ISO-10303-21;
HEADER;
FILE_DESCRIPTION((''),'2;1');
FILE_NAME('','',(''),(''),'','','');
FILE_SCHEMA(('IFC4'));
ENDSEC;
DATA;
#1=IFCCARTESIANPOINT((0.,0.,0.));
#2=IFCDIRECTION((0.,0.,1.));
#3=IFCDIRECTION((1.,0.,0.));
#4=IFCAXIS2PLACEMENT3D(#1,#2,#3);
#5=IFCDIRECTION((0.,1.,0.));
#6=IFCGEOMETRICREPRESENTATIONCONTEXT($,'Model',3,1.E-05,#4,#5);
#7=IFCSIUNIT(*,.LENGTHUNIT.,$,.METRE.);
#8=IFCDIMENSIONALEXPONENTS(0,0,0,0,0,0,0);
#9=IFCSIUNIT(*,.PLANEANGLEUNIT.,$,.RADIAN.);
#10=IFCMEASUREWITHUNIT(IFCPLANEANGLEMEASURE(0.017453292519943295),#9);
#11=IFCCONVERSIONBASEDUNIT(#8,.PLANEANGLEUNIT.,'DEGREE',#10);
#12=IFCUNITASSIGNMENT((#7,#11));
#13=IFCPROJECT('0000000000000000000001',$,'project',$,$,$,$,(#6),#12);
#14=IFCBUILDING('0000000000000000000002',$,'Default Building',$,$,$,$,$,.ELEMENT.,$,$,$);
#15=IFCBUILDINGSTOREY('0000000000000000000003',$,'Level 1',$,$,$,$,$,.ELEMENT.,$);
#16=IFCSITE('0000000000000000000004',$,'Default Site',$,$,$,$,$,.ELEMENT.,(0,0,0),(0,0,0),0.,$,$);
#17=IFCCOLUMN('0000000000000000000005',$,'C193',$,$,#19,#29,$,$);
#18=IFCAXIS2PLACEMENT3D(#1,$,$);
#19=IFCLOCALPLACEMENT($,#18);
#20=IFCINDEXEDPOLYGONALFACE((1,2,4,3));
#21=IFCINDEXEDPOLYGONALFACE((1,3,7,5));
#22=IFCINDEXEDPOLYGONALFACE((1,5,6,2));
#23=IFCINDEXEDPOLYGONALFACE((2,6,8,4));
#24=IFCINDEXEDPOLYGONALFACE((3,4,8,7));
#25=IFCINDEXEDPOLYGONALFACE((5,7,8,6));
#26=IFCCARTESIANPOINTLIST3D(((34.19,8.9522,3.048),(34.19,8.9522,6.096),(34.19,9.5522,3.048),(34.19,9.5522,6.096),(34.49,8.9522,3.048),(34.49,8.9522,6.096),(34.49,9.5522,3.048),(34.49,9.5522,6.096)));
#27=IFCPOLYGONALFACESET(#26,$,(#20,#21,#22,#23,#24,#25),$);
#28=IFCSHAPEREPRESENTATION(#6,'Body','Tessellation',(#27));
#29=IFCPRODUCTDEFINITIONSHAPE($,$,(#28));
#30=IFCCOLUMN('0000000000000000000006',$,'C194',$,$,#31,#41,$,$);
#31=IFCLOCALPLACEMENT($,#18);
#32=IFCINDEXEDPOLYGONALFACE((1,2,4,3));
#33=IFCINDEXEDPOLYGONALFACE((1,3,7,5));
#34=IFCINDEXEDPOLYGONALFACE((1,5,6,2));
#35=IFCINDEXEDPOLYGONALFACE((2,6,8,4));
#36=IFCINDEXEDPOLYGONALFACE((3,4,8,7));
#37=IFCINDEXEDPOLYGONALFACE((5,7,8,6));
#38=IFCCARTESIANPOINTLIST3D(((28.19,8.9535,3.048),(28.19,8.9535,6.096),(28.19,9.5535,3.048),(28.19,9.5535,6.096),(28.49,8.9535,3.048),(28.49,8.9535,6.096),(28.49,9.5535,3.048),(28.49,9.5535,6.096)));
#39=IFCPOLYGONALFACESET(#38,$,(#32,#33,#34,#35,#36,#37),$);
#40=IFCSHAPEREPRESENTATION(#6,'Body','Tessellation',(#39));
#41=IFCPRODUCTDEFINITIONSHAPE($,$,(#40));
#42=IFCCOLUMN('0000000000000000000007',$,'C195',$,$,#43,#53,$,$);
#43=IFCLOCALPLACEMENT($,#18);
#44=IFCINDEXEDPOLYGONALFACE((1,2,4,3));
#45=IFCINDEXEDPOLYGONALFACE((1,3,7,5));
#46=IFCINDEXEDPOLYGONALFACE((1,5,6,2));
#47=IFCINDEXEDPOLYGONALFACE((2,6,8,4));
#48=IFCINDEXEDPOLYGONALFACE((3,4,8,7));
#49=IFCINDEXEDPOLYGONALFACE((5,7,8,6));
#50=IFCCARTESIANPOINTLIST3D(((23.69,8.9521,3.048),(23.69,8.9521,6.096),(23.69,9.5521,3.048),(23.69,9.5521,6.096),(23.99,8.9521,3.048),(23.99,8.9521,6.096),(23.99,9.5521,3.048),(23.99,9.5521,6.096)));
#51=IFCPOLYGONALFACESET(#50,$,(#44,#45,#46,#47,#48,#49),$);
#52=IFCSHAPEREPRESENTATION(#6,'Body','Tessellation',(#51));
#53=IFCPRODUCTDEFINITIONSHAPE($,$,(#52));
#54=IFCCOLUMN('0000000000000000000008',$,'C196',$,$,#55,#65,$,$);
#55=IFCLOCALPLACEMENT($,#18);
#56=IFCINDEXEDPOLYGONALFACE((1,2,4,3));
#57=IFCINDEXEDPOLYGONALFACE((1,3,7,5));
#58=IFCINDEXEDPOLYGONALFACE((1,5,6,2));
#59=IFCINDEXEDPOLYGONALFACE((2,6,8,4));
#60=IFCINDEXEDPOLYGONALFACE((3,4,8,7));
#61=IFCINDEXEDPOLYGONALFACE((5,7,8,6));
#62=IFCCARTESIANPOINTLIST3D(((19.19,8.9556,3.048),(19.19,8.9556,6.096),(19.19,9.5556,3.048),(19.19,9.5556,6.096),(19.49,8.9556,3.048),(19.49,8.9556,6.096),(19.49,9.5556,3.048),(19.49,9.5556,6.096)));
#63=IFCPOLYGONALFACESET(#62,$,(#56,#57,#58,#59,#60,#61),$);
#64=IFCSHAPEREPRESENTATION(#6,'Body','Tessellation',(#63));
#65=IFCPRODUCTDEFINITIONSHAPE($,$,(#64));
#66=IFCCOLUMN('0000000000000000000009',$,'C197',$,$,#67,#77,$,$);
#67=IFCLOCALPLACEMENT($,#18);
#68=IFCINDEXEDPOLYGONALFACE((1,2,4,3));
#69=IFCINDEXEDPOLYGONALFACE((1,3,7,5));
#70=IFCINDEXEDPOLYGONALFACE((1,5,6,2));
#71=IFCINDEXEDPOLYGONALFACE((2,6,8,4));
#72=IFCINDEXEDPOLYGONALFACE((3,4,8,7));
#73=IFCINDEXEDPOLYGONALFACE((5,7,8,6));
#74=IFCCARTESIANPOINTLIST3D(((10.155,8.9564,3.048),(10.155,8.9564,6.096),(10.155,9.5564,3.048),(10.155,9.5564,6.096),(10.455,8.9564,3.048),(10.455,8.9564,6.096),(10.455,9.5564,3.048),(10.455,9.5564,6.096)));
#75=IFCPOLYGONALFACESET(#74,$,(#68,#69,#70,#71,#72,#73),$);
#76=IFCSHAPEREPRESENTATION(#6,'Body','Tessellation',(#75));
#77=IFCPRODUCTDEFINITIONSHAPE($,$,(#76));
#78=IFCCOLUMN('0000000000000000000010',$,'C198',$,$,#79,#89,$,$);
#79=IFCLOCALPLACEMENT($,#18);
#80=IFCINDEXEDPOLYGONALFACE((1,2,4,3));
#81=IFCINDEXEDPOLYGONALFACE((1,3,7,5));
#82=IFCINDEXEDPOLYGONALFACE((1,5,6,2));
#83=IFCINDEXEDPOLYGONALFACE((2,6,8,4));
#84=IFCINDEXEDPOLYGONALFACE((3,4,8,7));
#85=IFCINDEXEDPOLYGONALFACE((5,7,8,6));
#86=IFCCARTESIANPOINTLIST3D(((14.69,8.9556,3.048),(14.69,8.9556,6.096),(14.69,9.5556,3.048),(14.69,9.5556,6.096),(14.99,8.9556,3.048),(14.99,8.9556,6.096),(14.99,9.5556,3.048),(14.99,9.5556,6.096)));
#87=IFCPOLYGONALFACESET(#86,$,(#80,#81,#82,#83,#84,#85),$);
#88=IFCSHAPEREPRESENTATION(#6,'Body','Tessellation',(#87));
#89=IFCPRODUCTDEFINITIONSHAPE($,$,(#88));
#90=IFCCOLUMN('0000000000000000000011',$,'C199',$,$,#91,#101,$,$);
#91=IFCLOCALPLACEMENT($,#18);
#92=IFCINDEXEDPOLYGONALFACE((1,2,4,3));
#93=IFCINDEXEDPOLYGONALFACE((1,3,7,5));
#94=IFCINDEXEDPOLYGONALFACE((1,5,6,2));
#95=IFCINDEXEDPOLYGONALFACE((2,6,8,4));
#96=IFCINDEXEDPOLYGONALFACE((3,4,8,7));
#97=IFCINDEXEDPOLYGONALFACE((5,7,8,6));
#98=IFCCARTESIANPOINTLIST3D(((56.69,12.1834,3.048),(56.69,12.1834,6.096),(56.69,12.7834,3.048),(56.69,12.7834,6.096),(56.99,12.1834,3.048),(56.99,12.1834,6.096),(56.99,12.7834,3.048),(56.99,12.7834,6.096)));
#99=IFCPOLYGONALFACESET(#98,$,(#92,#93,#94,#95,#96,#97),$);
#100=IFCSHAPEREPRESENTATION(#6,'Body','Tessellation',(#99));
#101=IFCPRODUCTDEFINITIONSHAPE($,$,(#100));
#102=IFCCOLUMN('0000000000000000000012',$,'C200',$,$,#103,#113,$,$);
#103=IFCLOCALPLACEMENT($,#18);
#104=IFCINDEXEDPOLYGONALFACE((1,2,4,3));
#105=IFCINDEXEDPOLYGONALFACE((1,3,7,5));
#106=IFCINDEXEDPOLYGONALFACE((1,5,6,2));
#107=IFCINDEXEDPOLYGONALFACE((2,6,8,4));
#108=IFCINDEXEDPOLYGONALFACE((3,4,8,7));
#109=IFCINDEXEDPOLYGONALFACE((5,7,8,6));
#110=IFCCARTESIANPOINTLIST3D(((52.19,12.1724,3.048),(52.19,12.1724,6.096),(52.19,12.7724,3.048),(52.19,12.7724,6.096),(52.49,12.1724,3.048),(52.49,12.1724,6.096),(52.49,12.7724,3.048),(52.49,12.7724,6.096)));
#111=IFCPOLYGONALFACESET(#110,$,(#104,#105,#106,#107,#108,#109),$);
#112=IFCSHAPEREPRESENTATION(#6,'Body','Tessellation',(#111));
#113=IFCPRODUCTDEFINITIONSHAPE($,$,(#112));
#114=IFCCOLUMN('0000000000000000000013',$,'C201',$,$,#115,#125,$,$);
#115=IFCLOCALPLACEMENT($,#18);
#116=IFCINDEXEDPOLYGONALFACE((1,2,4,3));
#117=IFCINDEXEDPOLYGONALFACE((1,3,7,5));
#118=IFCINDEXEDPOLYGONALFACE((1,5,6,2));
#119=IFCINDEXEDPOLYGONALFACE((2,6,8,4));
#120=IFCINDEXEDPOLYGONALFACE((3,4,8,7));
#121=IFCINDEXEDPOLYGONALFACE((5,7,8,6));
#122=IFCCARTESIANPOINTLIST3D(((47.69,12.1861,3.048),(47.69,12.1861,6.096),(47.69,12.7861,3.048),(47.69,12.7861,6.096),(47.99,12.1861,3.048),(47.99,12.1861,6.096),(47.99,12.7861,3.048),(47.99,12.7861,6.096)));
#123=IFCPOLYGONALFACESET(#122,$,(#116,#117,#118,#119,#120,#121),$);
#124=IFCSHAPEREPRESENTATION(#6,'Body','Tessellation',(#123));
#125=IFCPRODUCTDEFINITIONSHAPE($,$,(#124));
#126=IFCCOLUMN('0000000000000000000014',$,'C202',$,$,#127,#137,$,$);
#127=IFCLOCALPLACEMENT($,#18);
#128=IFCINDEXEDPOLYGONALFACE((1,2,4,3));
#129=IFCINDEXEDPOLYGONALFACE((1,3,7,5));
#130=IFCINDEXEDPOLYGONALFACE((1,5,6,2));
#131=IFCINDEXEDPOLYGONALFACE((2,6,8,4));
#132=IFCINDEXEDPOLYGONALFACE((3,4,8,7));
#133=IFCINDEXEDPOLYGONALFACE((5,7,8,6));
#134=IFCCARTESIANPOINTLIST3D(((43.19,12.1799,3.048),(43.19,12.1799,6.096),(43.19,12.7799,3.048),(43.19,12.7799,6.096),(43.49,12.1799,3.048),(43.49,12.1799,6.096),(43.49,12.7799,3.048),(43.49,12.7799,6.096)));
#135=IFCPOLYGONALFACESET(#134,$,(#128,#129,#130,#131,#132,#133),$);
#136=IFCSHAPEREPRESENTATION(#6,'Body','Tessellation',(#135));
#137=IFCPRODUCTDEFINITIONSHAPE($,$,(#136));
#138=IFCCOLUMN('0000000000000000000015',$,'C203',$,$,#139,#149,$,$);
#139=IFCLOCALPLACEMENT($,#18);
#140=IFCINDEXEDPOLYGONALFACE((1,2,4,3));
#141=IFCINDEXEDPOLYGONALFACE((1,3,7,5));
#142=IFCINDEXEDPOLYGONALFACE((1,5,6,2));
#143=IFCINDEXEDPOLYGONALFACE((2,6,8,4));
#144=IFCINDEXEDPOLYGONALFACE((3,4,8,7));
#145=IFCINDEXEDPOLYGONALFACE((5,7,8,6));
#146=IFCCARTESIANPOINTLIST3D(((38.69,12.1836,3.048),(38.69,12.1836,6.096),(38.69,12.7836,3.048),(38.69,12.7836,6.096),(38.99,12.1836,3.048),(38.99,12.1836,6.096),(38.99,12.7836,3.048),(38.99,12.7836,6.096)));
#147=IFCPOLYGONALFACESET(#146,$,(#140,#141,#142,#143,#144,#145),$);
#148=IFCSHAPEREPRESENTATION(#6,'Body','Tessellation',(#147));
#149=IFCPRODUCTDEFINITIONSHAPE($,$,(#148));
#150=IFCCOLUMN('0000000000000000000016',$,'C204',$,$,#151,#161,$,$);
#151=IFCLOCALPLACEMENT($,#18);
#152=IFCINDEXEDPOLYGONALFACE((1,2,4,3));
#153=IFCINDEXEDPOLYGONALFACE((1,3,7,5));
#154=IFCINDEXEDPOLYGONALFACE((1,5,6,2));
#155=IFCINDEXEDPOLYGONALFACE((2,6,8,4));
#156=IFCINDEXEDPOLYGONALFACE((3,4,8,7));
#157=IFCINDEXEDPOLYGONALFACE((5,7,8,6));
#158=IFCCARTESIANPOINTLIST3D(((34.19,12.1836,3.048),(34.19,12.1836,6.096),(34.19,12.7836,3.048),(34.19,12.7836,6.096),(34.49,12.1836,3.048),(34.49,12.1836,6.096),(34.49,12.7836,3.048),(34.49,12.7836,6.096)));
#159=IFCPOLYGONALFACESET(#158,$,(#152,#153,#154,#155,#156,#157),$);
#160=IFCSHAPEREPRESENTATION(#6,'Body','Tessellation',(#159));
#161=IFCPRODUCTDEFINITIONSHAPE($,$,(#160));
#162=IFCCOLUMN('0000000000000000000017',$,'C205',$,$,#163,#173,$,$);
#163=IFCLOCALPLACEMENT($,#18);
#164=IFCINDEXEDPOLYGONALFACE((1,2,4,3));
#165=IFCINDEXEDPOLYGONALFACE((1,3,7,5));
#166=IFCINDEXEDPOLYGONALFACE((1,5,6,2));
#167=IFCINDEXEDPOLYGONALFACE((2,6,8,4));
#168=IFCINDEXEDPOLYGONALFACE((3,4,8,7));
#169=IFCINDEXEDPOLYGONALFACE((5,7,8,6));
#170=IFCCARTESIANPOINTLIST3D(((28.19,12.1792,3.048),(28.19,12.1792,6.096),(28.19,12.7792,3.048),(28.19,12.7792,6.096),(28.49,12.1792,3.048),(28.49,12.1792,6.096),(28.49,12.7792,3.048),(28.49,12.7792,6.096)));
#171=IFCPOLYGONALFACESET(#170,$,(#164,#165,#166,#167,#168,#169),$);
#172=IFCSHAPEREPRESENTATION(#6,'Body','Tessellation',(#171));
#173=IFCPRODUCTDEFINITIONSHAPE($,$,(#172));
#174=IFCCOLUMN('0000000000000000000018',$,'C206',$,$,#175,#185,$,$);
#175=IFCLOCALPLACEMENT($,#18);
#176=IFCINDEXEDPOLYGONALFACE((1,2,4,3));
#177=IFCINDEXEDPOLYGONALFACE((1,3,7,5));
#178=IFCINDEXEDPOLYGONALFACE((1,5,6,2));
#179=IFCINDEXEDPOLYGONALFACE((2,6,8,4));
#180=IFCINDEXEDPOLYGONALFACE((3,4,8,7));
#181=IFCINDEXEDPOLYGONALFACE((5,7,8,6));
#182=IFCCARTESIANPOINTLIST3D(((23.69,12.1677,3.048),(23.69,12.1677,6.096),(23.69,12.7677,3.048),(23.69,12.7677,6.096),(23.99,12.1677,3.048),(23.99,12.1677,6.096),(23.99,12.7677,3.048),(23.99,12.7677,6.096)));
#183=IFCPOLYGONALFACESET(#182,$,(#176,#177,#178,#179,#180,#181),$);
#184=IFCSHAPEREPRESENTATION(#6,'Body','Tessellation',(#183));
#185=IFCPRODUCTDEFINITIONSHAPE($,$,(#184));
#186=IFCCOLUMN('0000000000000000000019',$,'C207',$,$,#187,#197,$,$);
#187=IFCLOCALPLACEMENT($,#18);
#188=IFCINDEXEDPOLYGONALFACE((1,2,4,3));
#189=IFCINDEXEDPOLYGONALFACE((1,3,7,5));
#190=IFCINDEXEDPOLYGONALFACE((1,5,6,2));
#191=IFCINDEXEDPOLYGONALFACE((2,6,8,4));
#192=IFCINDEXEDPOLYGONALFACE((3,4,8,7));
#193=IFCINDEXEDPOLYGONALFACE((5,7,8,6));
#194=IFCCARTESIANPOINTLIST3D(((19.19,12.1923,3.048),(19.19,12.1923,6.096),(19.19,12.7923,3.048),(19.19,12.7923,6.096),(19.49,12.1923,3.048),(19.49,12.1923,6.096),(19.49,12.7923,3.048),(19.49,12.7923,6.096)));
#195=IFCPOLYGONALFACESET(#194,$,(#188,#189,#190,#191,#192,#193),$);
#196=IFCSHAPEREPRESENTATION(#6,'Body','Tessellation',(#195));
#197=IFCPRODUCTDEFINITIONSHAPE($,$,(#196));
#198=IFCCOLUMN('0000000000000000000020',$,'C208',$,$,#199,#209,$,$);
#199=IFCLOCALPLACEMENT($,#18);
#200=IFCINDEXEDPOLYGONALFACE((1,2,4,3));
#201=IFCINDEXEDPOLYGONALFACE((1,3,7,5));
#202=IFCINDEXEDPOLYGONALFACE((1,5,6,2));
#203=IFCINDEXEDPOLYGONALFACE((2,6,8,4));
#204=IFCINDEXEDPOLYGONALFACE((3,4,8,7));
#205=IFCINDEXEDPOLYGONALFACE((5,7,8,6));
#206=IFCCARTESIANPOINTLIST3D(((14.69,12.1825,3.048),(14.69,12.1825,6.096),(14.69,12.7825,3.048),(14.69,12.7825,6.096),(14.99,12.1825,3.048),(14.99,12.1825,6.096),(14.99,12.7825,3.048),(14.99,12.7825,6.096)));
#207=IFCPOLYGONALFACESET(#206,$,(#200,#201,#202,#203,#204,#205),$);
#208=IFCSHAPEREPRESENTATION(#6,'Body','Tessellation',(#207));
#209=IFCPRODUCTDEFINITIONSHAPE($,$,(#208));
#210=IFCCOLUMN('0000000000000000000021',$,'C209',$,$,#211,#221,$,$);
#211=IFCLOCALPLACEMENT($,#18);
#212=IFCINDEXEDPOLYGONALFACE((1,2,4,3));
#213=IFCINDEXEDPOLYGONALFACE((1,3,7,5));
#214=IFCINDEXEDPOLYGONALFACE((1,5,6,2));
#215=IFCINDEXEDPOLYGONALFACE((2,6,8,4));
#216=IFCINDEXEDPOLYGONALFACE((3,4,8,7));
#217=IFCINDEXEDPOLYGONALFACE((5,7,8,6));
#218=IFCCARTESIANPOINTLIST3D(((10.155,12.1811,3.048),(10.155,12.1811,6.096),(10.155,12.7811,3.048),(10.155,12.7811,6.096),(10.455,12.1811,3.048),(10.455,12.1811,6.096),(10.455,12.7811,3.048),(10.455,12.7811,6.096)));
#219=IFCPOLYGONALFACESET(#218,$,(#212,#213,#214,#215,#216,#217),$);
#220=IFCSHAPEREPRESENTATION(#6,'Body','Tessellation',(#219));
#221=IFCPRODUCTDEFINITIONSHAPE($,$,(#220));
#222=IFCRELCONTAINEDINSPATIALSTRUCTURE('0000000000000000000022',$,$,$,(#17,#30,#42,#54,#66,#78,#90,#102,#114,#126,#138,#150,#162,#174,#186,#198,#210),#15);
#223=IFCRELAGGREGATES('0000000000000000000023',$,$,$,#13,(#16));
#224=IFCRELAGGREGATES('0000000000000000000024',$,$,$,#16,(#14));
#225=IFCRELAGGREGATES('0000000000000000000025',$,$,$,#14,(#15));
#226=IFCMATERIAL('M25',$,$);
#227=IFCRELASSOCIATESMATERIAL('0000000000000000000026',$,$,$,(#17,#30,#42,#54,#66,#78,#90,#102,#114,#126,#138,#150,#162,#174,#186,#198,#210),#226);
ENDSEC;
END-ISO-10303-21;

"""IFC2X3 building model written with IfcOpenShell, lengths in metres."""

from ifc_helpers import new_model, entity, si_unit, converted_unit, direction, frame, frame_2d, origin_with_axes, place, context, project, spatial, rectangle, extrude, material, element, save


model = new_model("IFC2X3")

# Units and contexts
model_context = context("Model", 3, precision=1e-05, world=origin_with_axes(), true_north=direction((0.0, 1.0, 0.0)))
ifc_project = project(units=[si_unit("LENGTHUNIT", "METRE"), converted_unit("PLANEANGLEUNIT", "DEGREE", entity("IfcPlaneAngleMeasure", 0.017453292519943295), si_unit("PLANEANGLEUNIT", "RADIAN"), dimensions=[0, 0, 0, 0, 0, 0, 0])], contexts=[model_context])

# Site, building, storey
site = spatial("IfcSite", under=ifc_project, Name="Default Site", CompositionType="ELEMENT", RefLatitude=(0, 0, 0), RefLongitude=(0, 0, 0), RefElevation=0.0)
building = spatial("IfcBuilding", under=site, Name="Default Building", CompositionType="ELEMENT")
storey = spatial("IfcBuildingStorey", under=building, Name="Level 1", CompositionType="ELEMENT")

# Columns
ifc_material = material(Name="M25")
placement = place(None, origin_with_axes())
element("IfcColumn", 1, at=placement, inside=storey, material=ifc_material, Name="C193", context=model_context, shape_type="SweptSolid", body=[
    extrude(rectangle(XDim=0.3, YDim=0.6, at=frame_2d((0.0, 0.0), x_axis=(1.0, 0.0, 0.0))), frame((34.34, 9.2522, 3.048), z_axis=(0.0, 0.0, 1.0), x_axis=(1.0, 0.0, 0.0)), (0.0, 0.0, 1.0), 3.048),
])
element("IfcColumn", 2, at=placement, inside=storey, material=ifc_material, Name="C194", context=model_context, shape_type="SweptSolid", body=[
    extrude(rectangle(XDim=0.3, YDim=0.6, at=frame_2d((0.0, 0.0), x_axis=(1.0, 0.0, 0.0))), frame((28.34, 9.2535, 3.048), z_axis=(0.0, 0.0, 1.0), x_axis=(1.0, 0.0, 0.0)), (0.0, 0.0, 1.0), 3.048),
])
element("IfcColumn", 3, at=placement, inside=storey, material=ifc_material, Name="C195", context=model_context, shape_type="SweptSolid", body=[
    extrude(rectangle(XDim=0.3, YDim=0.6, at=frame_2d((0.0, 0.0), x_axis=(1.0, 0.0, 0.0))), frame((23.84, 9.2521, 3.048), z_axis=(0.0, 0.0, 1.0), x_axis=(1.0, 0.0, 0.0)), (0.0, 0.0, 1.0), 3.048),
])
element("IfcColumn", 4, at=placement, inside=storey, material=ifc_material, Name="C196", context=model_context, shape_type="SweptSolid", body=[
    extrude(rectangle(XDim=0.3, YDim=0.6, at=frame_2d((0.0, 0.0), x_axis=(1.0, 0.0, 0.0))), frame((19.34, 9.2556, 3.048), z_axis=(0.0, 0.0, 1.0), x_axis=(1.0, 0.0, 0.0)), (0.0, 0.0, 1.0), 3.048),
])
element("IfcColumn", 5, at=placement, inside=storey, material=ifc_material, Name="C197", context=model_context, shape_type="SweptSolid", body=[
    extrude(rectangle(XDim=0.3, YDim=0.6, at=frame_2d((0.0, 0.0), x_axis=(1.0, 0.0, 0.0))), frame((10.305, 9.2564, 3.048), z_axis=(0.0, 0.0, 1.0), x_axis=(1.0, 0.0, 0.0)), (0.0, 0.0, 1.0), 3.048),
])
element("IfcColumn", 6, at=placement, inside=storey, material=ifc_material, Name="C198", context=model_context, shape_type="SweptSolid", body=[
    extrude(rectangle(XDim=0.3, YDim=0.6, at=frame_2d((0.0, 0.0), x_axis=(1.0, 0.0, 0.0))), frame((14.84, 9.2556, 3.048), z_axis=(0.0, 0.0, 1.0), x_axis=(1.0, 0.0, 0.0)), (0.0, 0.0, 1.0), 3.048),
])
element("IfcColumn", 7, at=placement, inside=storey, material=ifc_material, Name="C199", context=model_context, shape_type="SweptSolid", body=[
    extrude(rectangle(XDim=0.3, YDim=0.6, at=frame_2d((0.0, 0.0), x_axis=(1.0, 0.0, 0.0))), frame((56.84, 12.4834, 3.048), z_axis=(0.0, 0.0, 1.0), x_axis=(1.0, 0.0, 0.0)), (0.0, 0.0, 1.0), 3.048),
])
element("IfcColumn", 8, at=placement, inside=storey, material=ifc_material, Name="C200", context=model_context, shape_type="SweptSolid", body=[
    extrude(rectangle(XDim=0.3, YDim=0.6, at=frame_2d((0.0, 0.0), x_axis=(1.0, 0.0, 0.0))), frame((52.34, 12.4724, 3.048), z_axis=(0.0, 0.0, 1.0), x_axis=(1.0, 0.0, 0.0)), (0.0, 0.0, 1.0), 3.048),
])
element("IfcColumn", 9, at=placement, inside=storey, material=ifc_material, Name="C201", context=model_context, shape_type="SweptSolid", body=[
    extrude(rectangle(XDim=0.3, YDim=0.6, at=frame_2d((0.0, 0.0), x_axis=(1.0, 0.0, 0.0))), frame((47.84, 12.4861, 3.048), z_axis=(0.0, 0.0, 1.0), x_axis=(1.0, 0.0, 0.0)), (0.0, 0.0, 1.0), 3.048),
])
element("IfcColumn", 10, at=placement, inside=storey, material=ifc_material, Name="C202", context=model_context, shape_type="SweptSolid", body=[
    extrude(rectangle(XDim=0.3, YDim=0.6, at=frame_2d((0.0, 0.0), x_axis=(1.0, 0.0, 0.0))), frame((43.34, 12.4799, 3.048), z_axis=(0.0, 0.0, 1.0), x_axis=(1.0, 0.0, 0.0)), (0.0, 0.0, 1.0), 3.048),
])
element("IfcColumn", 11, at=placement, inside=storey, material=ifc_material, Name="C203", context=model_context, shape_type="SweptSolid", body=[
    extrude(rectangle(XDim=0.3, YDim=0.6, at=frame_2d((0.0, 0.0), x_axis=(1.0, 0.0, 0.0))), frame((38.84, 12.4836, 3.048), z_axis=(0.0, 0.0, 1.0), x_axis=(1.0, 0.0, 0.0)), (0.0, 0.0, 1.0), 3.048),
])
element("IfcColumn", 12, at=placement, inside=storey, material=ifc_material, Name="C204", context=model_context, shape_type="SweptSolid", body=[
    extrude(rectangle(XDim=0.3, YDim=0.6, at=frame_2d((0.0, 0.0), x_axis=(1.0, 0.0, 0.0))), frame((34.34, 12.4836, 3.048), z_axis=(0.0, 0.0, 1.0), x_axis=(1.0, 0.0, 0.0)), (0.0, 0.0, 1.0), 3.048),
])
element("IfcColumn", 13, at=placement, inside=storey, material=ifc_material, Name="C205", context=model_context, shape_type="SweptSolid", body=[
    extrude(rectangle(XDim=0.3, YDim=0.6, at=frame_2d((0.0, 0.0), x_axis=(1.0, 0.0, 0.0))), frame((28.34, 12.4792, 3.048), z_axis=(0.0, 0.0, 1.0), x_axis=(1.0, 0.0, 0.0)), (0.0, 0.0, 1.0), 3.048),
])
element("IfcColumn", 14, at=placement, inside=storey, material=ifc_material, Name="C206", context=model_context, shape_type="SweptSolid", body=[
    extrude(rectangle(XDim=0.3, YDim=0.6, at=frame_2d((0.0, 0.0), x_axis=(1.0, 0.0, 0.0))), frame((23.84, 12.4677, 3.048), z_axis=(0.0, 0.0, 1.0), x_axis=(1.0, 0.0, 0.0)), (0.0, 0.0, 1.0), 3.048),
])
element("IfcColumn", 15, at=placement, inside=storey, material=ifc_material, Name="C207", context=model_context, shape_type="SweptSolid", body=[
    extrude(rectangle(XDim=0.3, YDim=0.6, at=frame_2d((0.0, 0.0), x_axis=(1.0, 0.0, 0.0))), frame((19.34, 12.4923, 3.048), z_axis=(0.0, 0.0, 1.0), x_axis=(1.0, 0.0, 0.0)), (0.0, 0.0, 1.0), 3.048),
])
element("IfcColumn", 16, at=placement, inside=storey, material=ifc_material, Name="C208", context=model_context, shape_type="SweptSolid", body=[
    extrude(rectangle(XDim=0.3, YDim=0.6, at=frame_2d((0.0, 0.0), x_axis=(1.0, 0.0, 0.0))), frame((14.84, 12.4825, 3.048), z_axis=(0.0, 0.0, 1.0), x_axis=(1.0, 0.0, 0.0)), (0.0, 0.0, 1.0), 3.048),
])
element("IfcColumn", 17, at=placement, inside=storey, material=ifc_material, Name="C209", context=model_context, shape_type="SweptSolid", body=[
    extrude(rectangle(XDim=0.3, YDim=0.6, at=frame_2d((0.0, 0.0), x_axis=(1.0, 0.0, 0.0))), frame((10.305, 12.4811, 3.048), z_axis=(0.0, 0.0, 1.0), x_axis=(1.0, 0.0, 0.0)), (0.0, 0.0, 1.0), 3.048),
])

save(model, "model.ifc")
